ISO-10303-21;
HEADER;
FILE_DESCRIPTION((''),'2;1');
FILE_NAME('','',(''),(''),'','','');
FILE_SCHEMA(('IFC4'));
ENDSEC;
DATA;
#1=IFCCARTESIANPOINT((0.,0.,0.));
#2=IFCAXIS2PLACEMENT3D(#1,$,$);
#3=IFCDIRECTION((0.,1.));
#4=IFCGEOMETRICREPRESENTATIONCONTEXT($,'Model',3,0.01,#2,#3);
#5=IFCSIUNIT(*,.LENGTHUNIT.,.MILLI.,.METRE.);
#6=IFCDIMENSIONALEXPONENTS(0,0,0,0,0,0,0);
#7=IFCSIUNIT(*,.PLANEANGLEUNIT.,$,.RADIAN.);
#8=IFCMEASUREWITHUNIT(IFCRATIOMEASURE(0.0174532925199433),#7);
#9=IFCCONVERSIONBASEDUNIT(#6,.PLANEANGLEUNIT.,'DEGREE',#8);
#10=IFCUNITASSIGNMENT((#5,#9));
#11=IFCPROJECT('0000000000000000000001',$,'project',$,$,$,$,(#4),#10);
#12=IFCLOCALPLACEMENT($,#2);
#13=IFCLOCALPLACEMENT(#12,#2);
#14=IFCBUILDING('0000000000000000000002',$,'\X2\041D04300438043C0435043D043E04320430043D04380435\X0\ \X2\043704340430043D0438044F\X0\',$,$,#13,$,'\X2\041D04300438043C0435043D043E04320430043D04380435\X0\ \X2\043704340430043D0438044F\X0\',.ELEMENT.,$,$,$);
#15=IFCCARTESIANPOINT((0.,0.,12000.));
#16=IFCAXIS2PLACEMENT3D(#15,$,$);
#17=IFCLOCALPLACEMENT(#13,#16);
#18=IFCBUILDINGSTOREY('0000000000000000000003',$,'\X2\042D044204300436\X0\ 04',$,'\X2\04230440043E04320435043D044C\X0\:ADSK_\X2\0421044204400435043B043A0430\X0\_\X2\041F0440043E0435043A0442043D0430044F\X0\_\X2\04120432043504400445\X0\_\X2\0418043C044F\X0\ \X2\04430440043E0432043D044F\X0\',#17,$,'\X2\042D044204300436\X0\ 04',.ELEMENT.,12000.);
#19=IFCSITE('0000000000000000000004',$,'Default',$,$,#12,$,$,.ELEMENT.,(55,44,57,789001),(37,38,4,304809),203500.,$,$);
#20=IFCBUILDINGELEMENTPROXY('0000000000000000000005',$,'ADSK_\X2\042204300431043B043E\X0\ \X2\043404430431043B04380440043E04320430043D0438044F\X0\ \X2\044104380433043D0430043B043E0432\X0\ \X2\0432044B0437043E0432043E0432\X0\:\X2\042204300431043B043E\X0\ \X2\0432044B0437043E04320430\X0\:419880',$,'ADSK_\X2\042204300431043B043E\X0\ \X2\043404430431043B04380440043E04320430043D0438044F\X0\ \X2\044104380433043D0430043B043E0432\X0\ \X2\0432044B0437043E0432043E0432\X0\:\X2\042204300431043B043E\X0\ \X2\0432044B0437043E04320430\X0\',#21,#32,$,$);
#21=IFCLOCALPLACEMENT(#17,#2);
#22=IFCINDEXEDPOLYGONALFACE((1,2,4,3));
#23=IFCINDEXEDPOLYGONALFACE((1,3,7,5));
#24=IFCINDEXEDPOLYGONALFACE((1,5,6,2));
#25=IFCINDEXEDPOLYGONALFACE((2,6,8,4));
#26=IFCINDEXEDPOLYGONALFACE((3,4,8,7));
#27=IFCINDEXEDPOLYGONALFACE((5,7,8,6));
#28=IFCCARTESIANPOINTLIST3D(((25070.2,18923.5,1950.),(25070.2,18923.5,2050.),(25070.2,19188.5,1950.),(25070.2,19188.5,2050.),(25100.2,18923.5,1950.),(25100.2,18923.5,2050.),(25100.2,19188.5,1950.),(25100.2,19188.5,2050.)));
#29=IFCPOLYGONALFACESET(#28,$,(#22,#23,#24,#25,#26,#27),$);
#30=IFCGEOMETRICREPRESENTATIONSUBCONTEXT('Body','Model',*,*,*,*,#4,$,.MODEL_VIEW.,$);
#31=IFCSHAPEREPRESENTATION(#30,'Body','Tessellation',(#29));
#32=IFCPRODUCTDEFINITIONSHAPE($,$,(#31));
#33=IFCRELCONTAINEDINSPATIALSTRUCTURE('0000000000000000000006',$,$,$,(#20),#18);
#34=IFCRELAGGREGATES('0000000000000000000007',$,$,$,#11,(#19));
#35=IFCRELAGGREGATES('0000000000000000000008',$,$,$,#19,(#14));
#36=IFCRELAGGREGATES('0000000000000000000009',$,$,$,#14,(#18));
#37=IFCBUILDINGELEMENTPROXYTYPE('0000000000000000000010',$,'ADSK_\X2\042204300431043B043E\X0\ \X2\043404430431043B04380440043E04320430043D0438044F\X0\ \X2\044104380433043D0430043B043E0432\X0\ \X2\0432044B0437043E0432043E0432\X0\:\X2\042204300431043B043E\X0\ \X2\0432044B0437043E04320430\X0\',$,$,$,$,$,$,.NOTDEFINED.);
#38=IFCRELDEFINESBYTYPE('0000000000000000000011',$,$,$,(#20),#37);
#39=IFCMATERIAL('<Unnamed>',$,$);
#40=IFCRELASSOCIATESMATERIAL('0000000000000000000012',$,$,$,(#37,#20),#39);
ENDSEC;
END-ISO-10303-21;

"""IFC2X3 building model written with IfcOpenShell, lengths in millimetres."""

from ifc_helpers import new_model, entity, si_unit, converted_unit, direction, frame, origin, origin_2d_with_axis, place, context, subcontext, project, spatial, rectangle, extrude, source, transform, mapped, material, type_object, type_shapes, element, save


model = new_model("IFC2X3")

# Units and contexts
model_context = context("Model", 3, precision=0.01, world=origin(), true_north=direction((0.0, 1.0)))
body_context = subcontext(model_context, "Body", "Model", "MODEL_VIEW")
ifc_project = project(units=[si_unit("LENGTHUNIT", "METRE", prefix="MILLI"), converted_unit("PLANEANGLEUNIT", "DEGREE", entity("IfcRatioMeasure", 0.0174532925199433), si_unit("PLANEANGLEUNIT", "RADIAN"), dimensions=[0, 0, 0, 0, 0, 0, 0])], contexts=[model_context])

# Site, building, storey
site_placement = place(None, origin())
site = spatial("IfcSite", under=ifc_project, at=site_placement, Name="Default", CompositionType="ELEMENT", RefLatitude=(55, 44, 57, 789001), RefLongitude=(37, 38, 4, 304809), RefElevation=203500.0)
building_placement = place(site_placement, origin())
building = spatial("IfcBuilding", under=site, at=building_placement, Name="Наименование здания", LongName="Наименование здания", CompositionType="ELEMENT")
storey_placement = place(building_placement, frame((0.0, 0.0, 12000.0)))
storey = spatial("IfcBuildingStorey", under=building, at=storey_placement, Name="Этаж 04", ObjectType="Уровень:ADSK_Стрелка_Проектная_Вверх_Имя уровня", LongName="Этаж 04", CompositionType="ELEMENT", Elevation=12000.0)

# Building element proxy
ifc_material_1 = material(Name="<Unnamed>")
building_element_proxy_type_1 = type_object("IfcBuildingElementProxyType", Name="ADSK_Табло дублирования сигналов вызовов:Табло вызова", PredefinedType="NOTDEFINED", material=ifc_material_1)
shared_shape_1 = source(origin(), body_context, "Body", "SweptSolid", [
    extrude(rectangle(XDim=265.0, YDim=30.0, at=origin_2d_with_axis()), frame((132.5, 15.0, 0.0), z_axis=(0.0, 0.0, 1.0), x_axis=(-1.0, 0.0, 0.0)), (0.0, 0.0, 1.0), 100.0),
])
type_shapes(building_element_proxy_type_1, [shared_shape_1])
proxy_1_placement = place(storey_placement, frame((25100.2, 18923.5, 1950.0), z_axis=(0.0, 0.0, 1.0), x_axis=(0.0, 1.0, 0.0)))
element("IfcBuildingElementProxy", 1, at=proxy_1_placement, inside=storey, type_object=building_element_proxy_type_1, material=ifc_material_1, Name="ADSK_Табло дублирования сигналов вызовов:Табло вызова:419880", ObjectType="ADSK_Табло дублирования сигналов вызовов:Табло вызова", context=body_context, shape_type="MappedRepresentation", body=[
    mapped(shared_shape_1, transform((0.0, 0.0, 0.0), scale=1.0)),
])

save(model, "model.ifc")
